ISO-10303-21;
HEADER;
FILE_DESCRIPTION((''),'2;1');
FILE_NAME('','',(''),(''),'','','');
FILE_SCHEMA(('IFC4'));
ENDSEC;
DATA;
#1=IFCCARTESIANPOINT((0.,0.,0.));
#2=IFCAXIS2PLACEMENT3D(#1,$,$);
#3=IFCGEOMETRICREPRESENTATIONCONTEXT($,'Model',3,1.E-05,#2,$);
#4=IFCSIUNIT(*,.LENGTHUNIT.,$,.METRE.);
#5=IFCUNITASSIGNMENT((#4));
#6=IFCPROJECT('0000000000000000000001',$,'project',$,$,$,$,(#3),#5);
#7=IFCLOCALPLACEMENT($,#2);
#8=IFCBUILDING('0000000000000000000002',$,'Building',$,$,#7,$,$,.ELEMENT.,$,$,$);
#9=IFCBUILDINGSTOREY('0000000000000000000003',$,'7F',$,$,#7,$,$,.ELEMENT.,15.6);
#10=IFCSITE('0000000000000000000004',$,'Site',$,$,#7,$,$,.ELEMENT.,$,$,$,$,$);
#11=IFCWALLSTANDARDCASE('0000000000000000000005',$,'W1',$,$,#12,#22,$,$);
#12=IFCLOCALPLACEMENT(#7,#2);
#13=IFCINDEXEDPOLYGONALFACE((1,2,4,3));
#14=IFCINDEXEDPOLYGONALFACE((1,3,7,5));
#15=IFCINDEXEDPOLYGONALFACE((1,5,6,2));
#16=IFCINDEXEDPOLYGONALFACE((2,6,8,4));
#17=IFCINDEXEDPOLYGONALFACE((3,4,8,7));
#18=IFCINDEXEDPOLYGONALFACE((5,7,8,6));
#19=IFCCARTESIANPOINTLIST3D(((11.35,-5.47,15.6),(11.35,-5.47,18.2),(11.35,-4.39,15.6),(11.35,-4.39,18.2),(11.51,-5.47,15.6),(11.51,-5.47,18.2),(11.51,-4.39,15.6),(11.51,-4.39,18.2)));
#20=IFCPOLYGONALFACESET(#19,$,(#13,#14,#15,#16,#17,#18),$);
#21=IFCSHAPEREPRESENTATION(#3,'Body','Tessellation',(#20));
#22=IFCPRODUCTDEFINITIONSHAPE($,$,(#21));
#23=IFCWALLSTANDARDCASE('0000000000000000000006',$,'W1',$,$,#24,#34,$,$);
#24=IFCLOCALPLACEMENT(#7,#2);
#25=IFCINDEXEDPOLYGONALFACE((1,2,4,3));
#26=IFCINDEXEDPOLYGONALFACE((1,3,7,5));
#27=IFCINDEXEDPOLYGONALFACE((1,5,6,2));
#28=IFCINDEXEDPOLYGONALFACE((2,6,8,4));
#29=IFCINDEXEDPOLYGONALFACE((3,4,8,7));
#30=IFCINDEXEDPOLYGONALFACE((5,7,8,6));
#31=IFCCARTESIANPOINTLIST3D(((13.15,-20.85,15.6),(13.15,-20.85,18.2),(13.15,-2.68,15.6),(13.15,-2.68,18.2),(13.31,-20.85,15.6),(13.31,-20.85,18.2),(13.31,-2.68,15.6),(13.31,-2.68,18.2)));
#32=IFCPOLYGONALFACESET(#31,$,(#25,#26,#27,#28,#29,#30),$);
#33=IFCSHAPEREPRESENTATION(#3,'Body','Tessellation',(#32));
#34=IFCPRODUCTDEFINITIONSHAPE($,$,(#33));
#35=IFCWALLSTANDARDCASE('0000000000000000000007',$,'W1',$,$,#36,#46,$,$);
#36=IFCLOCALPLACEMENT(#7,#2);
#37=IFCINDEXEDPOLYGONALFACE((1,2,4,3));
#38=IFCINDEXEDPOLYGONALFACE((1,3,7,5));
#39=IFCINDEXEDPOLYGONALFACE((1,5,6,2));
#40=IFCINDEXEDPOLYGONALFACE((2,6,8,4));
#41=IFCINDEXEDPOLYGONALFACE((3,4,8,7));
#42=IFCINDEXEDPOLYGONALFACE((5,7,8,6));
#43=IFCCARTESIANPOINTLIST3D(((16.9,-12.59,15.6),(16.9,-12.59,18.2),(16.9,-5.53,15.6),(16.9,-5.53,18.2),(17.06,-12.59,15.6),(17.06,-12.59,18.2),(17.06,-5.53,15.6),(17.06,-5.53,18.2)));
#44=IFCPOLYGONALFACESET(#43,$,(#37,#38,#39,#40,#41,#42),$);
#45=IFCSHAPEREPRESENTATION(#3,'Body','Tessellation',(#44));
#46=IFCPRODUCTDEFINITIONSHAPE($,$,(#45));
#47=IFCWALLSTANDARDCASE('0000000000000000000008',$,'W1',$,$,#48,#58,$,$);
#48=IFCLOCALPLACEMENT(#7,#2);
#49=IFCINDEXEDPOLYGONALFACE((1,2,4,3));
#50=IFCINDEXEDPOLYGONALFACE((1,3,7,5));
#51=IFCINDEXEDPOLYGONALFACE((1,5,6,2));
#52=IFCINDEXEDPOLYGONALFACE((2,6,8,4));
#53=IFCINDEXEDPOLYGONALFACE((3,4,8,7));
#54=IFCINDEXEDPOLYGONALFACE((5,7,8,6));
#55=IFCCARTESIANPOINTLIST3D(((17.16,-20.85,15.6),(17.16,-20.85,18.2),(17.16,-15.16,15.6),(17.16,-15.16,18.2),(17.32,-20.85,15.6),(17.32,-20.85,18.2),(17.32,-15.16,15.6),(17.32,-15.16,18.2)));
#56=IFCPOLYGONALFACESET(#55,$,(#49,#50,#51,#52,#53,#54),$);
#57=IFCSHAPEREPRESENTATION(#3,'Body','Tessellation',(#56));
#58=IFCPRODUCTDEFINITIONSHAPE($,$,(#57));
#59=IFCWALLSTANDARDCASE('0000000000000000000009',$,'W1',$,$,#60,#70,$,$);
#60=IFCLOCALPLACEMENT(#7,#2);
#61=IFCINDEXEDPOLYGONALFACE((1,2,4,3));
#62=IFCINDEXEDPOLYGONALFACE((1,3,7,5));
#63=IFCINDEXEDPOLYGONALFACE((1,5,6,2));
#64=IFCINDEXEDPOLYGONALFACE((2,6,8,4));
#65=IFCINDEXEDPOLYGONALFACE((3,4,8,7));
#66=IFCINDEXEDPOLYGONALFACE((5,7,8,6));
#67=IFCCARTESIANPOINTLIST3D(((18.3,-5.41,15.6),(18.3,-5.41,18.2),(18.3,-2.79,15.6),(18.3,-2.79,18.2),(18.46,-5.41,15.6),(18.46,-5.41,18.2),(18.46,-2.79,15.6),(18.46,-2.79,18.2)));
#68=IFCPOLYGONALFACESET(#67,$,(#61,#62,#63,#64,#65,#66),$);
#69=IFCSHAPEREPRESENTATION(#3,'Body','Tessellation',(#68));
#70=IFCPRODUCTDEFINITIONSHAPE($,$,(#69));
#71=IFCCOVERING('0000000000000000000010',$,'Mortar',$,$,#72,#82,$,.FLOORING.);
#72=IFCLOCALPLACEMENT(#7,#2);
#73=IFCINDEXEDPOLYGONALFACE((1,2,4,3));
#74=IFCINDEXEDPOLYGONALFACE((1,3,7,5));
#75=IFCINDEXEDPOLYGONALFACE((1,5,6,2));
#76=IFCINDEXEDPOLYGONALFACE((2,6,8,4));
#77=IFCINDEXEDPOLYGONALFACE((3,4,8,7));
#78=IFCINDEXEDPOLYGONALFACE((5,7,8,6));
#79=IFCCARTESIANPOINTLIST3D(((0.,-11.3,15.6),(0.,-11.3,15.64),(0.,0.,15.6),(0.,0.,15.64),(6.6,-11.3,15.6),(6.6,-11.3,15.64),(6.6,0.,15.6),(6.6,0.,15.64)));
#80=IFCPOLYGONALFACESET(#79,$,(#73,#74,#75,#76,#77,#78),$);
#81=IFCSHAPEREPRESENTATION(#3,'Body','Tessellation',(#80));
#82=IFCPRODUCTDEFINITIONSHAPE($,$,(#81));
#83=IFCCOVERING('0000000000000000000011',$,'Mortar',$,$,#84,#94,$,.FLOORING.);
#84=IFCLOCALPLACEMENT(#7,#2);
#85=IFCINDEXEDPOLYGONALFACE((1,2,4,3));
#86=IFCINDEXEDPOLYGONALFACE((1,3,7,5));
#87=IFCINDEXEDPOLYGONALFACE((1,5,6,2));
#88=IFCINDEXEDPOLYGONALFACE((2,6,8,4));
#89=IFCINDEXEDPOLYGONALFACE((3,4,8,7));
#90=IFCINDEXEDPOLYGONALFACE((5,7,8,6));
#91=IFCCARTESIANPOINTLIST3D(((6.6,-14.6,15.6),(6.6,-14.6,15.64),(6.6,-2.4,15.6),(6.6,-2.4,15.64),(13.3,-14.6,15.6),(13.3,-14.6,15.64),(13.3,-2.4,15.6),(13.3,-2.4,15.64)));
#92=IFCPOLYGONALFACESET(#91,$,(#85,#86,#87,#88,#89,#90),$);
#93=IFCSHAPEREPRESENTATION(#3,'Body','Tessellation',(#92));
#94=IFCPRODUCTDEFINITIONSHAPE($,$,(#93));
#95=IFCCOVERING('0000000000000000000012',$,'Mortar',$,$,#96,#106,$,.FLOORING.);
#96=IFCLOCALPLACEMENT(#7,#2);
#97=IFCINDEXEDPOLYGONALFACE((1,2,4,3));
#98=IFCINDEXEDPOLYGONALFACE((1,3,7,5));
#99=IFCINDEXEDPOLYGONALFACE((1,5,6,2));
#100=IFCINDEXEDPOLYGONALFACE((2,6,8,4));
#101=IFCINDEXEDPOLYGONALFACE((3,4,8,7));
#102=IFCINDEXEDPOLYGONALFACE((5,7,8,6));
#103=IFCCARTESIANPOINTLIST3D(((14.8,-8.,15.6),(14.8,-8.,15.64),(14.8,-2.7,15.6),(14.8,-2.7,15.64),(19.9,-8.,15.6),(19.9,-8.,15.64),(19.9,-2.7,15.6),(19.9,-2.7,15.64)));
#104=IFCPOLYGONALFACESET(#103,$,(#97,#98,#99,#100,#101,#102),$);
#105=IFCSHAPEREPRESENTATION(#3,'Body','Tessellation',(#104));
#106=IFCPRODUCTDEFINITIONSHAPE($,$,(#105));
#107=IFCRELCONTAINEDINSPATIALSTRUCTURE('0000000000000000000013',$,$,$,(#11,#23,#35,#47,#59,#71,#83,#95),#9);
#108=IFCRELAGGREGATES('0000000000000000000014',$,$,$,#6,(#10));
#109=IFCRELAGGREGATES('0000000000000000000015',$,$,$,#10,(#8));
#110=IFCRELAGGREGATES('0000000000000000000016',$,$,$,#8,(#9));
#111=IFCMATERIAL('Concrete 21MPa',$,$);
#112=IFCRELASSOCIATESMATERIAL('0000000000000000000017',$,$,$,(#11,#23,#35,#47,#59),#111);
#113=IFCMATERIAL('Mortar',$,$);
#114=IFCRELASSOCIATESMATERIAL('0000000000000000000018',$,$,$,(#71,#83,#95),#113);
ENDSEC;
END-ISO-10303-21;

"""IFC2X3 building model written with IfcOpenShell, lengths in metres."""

from ifc_helpers import new_model, si_unit, frame, origin, origin_2d, place, context, project, spatial, rectangle, extrude, material, element, save


model = new_model("IFC2X3")

# Units and contexts
model_context = context("Model", 3, precision=1e-05, world=origin())
ifc_project = project(units=[si_unit("LENGTHUNIT", "METRE")], contexts=[model_context])

# Site, building, storey
placement = place(None, origin())
site = spatial("IfcSite", under=ifc_project, at=placement, Name="Site", CompositionType="ELEMENT")
building = spatial("IfcBuilding", under=site, at=placement, Name="Building", CompositionType="ELEMENT")
storey = spatial("IfcBuildingStorey", under=building, at=placement, Name="7F", CompositionType="ELEMENT", Elevation=15.6)

# Shared definitions
ifc_material_1 = material(Name="Concrete 21MPa")

# Walls
wall_1_placement = place(None, frame((11.43, -4.93, 15.6)))
element("IfcWallStandardCase", 1, at=wall_1_placement, inside=storey, material=ifc_material_1, Name="W1", context=model_context, shape_type="SweptSolid", body=[
    extrude(rectangle(XDim=0.16, YDim=1.08, at=origin_2d()), origin(), (0.0, 0.0, 1.0), 2.6),
])
wall_2_placement = place(None, frame((13.23, -11.765, 15.6)))
element("IfcWallStandardCase", 2, at=wall_2_placement, inside=storey, material=ifc_material_1, Name="W1", context=model_context, shape_type="SweptSolid", body=[
    extrude(rectangle(XDim=0.16, YDim=18.17, at=origin_2d()), origin(), (0.0, 0.0, 1.0), 2.6),
])
wall_3_placement = place(None, frame((16.98, -9.06, 15.6)))
element("IfcWallStandardCase", 3, at=wall_3_placement, inside=storey, material=ifc_material_1, Name="W1", context=model_context, shape_type="SweptSolid", body=[
    extrude(rectangle(XDim=0.16, YDim=7.06, at=origin_2d()), origin(), (0.0, 0.0, 1.0), 2.6),
])
wall_4_placement = place(None, frame((17.24, -18.005, 15.6)))
element("IfcWallStandardCase", 4, at=wall_4_placement, inside=storey, material=ifc_material_1, Name="W1", context=model_context, shape_type="SweptSolid", body=[
    extrude(rectangle(XDim=0.16, YDim=5.69, at=origin_2d()), origin(), (0.0, 0.0, 1.0), 2.6),
])
wall_5_placement = place(None, frame((18.38, -4.1, 15.6)))
element("IfcWallStandardCase", 5, at=wall_5_placement, inside=storey, material=ifc_material_1, Name="W1", context=model_context, shape_type="SweptSolid", body=[
    extrude(rectangle(XDim=0.16, YDim=2.62, at=origin_2d()), origin(), (0.0, 0.0, 1.0), 2.6),
])

# Coverings
ifc_material_2 = material(Name="Mortar")
covering_1_placement = place(None, frame((3.3, -5.65, 15.6)))
element("IfcCovering", 6, at=covering_1_placement, inside=storey, material=ifc_material_2, Name="Mortar", PredefinedType="FLOORING", context=model_context, shape_type="SweptSolid", body=[
    extrude(rectangle(XDim=6.6, YDim=11.3, at=origin_2d()), origin(), (0.0, 0.0, 1.0), 0.04),
])
covering_2_placement = place(None, frame((9.95, -8.5, 15.6)))
element("IfcCovering", 7, at=covering_2_placement, inside=storey, material=ifc_material_2, Name="Mortar", PredefinedType="FLOORING", context=model_context, shape_type="SweptSolid", body=[
    extrude(rectangle(XDim=6.7, YDim=12.2, at=origin_2d()), origin(), (0.0, 0.0, 1.0), 0.04),
])
covering_3_placement = place(None, frame((17.35, -5.35, 15.6)))
element("IfcCovering", 8, at=covering_3_placement, inside=storey, material=ifc_material_2, Name="Mortar", PredefinedType="FLOORING", context=model_context, shape_type="SweptSolid", body=[
    extrude(rectangle(XDim=5.1, YDim=5.3, at=origin_2d()), origin(), (0.0, 0.0, 1.0), 0.04),
])

save(model, "model.ifc")
